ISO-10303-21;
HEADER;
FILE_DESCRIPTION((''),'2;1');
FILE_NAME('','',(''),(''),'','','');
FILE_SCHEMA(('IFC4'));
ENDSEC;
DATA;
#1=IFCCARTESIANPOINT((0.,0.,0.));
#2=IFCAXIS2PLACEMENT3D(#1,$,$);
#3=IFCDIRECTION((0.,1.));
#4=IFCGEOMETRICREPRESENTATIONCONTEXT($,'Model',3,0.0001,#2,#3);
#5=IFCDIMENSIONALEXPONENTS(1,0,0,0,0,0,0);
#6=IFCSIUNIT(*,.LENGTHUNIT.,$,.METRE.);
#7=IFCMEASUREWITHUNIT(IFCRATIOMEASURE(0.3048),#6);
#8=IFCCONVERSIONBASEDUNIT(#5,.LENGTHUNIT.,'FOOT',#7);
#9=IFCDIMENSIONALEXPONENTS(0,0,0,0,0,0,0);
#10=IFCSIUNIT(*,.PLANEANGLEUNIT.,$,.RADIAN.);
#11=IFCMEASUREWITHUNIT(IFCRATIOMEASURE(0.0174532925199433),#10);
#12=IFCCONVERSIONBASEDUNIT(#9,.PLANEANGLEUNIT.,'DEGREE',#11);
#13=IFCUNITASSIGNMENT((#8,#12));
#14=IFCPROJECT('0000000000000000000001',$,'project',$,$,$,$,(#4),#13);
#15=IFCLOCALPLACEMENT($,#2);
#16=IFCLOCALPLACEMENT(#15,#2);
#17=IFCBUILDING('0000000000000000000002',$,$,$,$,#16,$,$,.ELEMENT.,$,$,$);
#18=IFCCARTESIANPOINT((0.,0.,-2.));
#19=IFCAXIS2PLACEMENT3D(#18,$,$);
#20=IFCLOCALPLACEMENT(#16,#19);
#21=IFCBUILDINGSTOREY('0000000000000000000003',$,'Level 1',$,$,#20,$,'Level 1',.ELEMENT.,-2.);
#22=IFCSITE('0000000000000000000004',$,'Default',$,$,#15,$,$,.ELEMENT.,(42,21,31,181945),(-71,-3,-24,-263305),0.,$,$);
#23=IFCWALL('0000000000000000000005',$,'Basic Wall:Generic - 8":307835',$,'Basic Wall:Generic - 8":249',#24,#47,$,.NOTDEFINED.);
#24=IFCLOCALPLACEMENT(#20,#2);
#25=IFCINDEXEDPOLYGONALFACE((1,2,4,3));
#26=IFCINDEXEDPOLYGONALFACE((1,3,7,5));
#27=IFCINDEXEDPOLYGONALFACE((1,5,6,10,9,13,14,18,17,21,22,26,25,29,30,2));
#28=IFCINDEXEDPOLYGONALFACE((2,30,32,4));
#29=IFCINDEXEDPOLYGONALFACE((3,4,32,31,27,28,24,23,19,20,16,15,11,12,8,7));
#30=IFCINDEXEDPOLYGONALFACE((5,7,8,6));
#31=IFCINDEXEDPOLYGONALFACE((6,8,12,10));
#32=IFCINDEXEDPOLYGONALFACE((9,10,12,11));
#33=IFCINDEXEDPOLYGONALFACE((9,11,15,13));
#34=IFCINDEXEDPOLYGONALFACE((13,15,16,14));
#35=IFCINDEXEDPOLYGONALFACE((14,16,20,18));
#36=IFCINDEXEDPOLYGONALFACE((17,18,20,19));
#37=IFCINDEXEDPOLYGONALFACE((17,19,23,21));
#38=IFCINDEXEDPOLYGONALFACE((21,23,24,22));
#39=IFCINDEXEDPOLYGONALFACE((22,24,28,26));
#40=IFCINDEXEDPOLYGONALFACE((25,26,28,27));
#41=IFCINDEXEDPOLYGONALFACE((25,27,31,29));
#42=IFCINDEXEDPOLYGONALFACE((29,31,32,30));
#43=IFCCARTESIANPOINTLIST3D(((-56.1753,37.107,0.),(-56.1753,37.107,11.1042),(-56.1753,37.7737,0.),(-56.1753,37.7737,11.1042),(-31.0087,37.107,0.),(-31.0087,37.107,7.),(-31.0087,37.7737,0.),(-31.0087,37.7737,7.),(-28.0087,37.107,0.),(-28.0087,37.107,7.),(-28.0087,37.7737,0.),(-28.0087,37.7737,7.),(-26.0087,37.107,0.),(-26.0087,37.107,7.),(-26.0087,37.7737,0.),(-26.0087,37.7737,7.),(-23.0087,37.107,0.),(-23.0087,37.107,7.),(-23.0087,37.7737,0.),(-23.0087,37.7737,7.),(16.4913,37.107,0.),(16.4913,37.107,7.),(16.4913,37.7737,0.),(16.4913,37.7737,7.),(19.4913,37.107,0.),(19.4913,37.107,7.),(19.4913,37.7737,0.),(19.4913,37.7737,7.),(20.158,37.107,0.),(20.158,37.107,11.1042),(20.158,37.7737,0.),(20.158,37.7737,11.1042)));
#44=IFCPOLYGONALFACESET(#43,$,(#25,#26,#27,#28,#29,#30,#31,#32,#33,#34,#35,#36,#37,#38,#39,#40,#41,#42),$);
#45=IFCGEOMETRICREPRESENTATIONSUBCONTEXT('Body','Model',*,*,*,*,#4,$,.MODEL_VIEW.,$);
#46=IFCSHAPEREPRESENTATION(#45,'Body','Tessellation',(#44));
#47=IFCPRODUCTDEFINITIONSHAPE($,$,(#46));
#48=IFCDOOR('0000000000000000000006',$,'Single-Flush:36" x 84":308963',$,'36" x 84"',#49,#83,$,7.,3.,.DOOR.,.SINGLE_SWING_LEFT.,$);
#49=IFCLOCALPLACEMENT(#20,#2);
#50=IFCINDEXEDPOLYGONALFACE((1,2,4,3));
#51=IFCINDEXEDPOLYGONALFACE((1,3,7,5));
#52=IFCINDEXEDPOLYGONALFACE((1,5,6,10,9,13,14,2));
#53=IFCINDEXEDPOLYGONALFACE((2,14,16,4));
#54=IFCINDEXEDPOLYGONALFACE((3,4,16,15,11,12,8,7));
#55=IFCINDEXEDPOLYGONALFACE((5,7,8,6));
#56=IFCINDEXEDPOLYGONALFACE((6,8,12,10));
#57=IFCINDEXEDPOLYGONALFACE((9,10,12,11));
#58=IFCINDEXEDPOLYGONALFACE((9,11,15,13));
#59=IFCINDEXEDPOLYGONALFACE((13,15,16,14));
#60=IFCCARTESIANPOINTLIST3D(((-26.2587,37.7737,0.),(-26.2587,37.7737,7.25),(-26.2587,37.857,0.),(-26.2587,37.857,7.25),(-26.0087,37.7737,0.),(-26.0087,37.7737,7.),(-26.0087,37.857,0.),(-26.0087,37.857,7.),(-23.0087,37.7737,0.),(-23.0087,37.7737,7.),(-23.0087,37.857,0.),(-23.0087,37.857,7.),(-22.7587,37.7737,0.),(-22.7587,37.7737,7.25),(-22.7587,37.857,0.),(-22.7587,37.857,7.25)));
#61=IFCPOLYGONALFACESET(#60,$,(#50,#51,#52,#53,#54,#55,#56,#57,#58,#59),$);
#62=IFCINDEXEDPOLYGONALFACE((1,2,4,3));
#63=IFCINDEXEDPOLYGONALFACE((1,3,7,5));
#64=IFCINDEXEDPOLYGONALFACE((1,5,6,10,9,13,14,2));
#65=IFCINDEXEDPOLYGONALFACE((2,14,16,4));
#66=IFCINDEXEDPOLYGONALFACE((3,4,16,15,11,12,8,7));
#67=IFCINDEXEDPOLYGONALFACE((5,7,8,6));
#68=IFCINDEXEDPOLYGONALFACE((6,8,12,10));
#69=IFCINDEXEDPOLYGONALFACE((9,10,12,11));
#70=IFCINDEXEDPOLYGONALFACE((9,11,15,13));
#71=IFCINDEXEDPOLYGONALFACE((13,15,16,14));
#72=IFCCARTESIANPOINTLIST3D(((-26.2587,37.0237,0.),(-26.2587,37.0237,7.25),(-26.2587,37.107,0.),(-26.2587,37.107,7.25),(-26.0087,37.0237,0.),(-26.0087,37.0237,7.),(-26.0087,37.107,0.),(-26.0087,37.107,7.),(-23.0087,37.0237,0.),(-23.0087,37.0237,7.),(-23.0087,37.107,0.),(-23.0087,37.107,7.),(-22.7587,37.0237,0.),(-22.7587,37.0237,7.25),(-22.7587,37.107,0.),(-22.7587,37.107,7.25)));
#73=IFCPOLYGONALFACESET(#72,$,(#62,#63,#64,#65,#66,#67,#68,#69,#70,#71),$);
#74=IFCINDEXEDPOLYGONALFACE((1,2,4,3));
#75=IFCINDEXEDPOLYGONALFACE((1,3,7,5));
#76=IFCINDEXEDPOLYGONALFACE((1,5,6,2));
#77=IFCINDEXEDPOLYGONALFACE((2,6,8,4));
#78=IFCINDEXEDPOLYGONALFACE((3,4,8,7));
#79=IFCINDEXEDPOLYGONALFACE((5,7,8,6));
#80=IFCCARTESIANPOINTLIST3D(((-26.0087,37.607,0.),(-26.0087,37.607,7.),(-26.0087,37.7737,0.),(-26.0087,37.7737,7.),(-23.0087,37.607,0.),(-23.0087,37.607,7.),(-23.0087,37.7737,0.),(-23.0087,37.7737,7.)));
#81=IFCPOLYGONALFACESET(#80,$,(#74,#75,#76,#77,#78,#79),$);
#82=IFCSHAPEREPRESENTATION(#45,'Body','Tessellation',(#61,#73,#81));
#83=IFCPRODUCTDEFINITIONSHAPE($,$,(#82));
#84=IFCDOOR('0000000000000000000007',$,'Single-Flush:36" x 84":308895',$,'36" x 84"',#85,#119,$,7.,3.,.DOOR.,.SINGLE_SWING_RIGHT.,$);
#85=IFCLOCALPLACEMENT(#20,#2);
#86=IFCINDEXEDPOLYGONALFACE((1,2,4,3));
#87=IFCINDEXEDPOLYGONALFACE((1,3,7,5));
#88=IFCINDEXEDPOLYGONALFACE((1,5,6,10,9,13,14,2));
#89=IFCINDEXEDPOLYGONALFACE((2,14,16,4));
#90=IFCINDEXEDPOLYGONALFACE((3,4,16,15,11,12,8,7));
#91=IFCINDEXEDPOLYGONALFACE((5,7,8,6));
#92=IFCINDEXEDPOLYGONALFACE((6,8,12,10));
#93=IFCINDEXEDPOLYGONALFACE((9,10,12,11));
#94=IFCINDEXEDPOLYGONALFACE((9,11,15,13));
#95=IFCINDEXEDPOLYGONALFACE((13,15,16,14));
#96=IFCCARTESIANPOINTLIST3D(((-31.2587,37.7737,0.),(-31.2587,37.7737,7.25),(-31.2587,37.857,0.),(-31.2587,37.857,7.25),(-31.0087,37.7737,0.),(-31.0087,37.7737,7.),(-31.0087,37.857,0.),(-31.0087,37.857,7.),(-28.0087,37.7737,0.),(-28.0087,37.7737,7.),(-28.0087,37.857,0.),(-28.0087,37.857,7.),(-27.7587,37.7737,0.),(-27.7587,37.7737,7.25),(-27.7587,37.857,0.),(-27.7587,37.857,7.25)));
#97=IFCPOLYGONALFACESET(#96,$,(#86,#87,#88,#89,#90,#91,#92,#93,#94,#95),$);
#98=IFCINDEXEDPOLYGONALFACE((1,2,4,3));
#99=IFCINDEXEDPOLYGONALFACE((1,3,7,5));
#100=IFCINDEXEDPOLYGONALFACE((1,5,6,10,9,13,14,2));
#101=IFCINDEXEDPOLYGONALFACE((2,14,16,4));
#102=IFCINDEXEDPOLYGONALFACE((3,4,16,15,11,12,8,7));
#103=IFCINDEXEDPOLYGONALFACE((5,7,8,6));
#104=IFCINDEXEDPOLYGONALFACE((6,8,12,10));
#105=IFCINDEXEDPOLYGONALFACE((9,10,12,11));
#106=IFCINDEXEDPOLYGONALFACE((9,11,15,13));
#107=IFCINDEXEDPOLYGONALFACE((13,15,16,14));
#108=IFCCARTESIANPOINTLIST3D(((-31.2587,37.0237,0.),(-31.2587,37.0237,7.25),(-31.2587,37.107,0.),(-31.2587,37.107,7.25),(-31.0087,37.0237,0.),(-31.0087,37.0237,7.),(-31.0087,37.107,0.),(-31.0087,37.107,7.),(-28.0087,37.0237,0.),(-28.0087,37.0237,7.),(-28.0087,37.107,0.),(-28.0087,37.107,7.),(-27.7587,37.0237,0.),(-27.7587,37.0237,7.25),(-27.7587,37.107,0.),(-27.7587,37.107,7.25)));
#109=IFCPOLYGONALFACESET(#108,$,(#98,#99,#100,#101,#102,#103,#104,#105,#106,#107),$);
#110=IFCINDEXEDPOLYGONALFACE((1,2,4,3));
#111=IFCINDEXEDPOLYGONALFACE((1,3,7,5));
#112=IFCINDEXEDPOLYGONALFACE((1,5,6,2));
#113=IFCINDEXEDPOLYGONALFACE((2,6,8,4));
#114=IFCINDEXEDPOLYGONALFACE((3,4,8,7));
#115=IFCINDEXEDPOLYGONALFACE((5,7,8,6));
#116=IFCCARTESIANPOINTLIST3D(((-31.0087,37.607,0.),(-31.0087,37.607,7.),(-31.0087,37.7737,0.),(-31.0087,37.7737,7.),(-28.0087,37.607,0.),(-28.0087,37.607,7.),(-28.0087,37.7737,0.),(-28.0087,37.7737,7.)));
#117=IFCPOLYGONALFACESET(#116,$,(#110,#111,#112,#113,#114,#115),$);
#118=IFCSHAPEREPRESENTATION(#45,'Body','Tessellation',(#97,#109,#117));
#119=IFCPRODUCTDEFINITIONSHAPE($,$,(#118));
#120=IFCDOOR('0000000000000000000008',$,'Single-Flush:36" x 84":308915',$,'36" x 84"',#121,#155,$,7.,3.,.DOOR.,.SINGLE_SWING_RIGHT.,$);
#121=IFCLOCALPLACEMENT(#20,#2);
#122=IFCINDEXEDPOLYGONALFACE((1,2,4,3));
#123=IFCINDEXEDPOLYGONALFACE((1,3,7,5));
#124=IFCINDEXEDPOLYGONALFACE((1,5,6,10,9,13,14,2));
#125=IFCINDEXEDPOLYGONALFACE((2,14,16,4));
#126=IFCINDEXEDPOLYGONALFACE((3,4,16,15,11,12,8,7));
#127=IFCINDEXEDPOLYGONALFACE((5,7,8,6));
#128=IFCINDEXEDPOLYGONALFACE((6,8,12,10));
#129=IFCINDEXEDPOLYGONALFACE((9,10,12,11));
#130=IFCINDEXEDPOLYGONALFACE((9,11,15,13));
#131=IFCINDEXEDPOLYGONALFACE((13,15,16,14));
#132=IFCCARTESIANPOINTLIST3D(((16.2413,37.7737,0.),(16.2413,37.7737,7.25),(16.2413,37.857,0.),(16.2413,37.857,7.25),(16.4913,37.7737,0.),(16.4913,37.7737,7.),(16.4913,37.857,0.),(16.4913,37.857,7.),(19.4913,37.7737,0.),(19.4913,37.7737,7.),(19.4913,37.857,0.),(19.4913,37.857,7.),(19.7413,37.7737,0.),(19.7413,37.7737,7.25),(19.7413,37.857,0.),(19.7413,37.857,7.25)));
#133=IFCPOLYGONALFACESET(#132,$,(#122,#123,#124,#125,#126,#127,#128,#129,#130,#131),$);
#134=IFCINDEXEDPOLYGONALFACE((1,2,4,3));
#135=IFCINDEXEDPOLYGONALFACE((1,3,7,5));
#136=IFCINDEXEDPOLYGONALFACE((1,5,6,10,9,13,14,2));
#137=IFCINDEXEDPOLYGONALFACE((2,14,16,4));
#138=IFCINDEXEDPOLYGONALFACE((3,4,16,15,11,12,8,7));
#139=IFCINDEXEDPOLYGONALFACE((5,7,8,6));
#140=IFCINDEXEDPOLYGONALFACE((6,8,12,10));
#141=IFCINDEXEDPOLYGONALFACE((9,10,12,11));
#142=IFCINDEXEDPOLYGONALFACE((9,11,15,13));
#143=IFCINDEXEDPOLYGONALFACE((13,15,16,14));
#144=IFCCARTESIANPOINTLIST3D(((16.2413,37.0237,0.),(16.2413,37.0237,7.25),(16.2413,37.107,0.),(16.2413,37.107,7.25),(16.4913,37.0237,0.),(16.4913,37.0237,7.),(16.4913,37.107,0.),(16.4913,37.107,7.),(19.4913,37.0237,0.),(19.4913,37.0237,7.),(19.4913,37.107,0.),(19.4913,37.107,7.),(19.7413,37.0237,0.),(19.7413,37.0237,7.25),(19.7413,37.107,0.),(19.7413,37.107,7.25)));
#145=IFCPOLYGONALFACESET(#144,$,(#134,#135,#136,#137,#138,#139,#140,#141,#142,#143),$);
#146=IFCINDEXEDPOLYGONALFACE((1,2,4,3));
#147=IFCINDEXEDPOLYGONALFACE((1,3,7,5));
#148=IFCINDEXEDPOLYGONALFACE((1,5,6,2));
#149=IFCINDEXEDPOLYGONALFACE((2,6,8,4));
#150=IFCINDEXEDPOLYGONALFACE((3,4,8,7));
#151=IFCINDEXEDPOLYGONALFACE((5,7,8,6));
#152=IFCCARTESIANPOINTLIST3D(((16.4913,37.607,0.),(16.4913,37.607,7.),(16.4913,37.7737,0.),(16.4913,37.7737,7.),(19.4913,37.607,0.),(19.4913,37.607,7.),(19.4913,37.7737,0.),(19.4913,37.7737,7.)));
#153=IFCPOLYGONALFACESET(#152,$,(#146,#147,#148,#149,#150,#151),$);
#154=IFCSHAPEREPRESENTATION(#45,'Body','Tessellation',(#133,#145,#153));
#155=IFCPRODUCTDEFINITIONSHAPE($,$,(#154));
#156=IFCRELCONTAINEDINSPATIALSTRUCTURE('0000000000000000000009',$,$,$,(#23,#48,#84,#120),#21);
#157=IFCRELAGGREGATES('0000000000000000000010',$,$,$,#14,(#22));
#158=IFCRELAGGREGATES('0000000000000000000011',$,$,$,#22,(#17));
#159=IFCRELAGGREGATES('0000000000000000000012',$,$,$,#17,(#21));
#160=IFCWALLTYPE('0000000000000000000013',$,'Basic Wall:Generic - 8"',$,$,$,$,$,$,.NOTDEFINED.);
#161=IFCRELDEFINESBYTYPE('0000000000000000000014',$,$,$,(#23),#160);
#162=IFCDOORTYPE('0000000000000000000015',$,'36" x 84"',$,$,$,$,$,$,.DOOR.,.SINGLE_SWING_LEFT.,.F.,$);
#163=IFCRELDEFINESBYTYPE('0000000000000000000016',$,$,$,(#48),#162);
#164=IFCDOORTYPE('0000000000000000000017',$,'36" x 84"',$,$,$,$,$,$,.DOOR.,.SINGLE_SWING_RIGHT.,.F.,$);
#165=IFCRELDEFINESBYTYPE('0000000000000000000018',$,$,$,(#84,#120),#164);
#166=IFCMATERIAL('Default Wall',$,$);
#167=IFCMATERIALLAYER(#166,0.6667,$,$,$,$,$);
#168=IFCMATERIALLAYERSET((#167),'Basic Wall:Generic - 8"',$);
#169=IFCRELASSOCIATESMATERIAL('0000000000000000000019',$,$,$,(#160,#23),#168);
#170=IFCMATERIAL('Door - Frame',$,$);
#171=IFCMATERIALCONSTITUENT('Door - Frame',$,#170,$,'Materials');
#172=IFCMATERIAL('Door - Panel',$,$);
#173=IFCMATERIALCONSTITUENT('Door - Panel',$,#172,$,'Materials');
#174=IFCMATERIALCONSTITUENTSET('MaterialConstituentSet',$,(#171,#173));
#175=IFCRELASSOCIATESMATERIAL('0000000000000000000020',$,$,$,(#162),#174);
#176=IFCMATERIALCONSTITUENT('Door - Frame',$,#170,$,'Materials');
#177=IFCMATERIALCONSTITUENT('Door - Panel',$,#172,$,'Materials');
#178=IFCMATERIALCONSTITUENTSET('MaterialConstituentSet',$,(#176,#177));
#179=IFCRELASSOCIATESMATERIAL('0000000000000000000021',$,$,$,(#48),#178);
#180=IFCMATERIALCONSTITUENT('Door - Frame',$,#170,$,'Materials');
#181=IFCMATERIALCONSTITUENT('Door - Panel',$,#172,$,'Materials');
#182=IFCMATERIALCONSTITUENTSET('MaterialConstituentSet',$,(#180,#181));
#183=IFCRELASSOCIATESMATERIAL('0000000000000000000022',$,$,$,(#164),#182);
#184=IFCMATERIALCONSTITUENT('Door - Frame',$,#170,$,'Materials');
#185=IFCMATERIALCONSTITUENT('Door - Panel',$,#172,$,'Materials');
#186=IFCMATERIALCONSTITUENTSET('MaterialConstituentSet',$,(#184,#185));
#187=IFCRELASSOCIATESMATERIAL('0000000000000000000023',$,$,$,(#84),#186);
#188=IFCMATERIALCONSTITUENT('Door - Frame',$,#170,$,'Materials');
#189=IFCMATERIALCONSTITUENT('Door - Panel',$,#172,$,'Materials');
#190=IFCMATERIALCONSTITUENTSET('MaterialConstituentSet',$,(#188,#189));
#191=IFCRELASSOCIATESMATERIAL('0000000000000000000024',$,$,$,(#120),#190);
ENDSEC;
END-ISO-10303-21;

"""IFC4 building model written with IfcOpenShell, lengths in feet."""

from ifc_helpers import new_model, entity, si_unit, converted_unit, direction, frame, frame_2d, origin, place, context, subcontext, project, spatial, polyline, rectangle, outline, extrude, clip, bounded_halfspace, source, transform, mapped, material, layer, layer_set, layer_usage, constituent, constituent_set, type_object, type_shapes, element, fill, save


model = new_model("IFC4")

# Units and contexts
model_context = context("Model", 3, precision=0.0001, world=origin(), true_north=direction((0.0, 1.0)))
body_context = subcontext(model_context, "Body", "Model", "MODEL_VIEW")
ifc_project = project(units=[converted_unit("LENGTHUNIT", "FOOT", entity("IfcRatioMeasure", 0.3048), si_unit("LENGTHUNIT", "METRE"), dimensions=[1, 0, 0, 0, 0, 0, 0]), converted_unit("PLANEANGLEUNIT", "DEGREE", entity("IfcRatioMeasure", 0.0174532925199433), si_unit("PLANEANGLEUNIT", "RADIAN"), dimensions=[0, 0, 0, 0, 0, 0, 0])], contexts=[model_context])

# Site, building, storey
site_placement = place(None, origin())
site = spatial("IfcSite", under=ifc_project, at=site_placement, Name="Default", CompositionType="ELEMENT", RefLatitude=(42, 21, 31, 181945), RefLongitude=(-71, -3, -24, -263305), RefElevation=0.0)
building_placement = place(site_placement, origin())
building = spatial("IfcBuilding", under=site, at=building_placement, CompositionType="ELEMENT")
storey_placement = place(building_placement, frame((0.0, 0.0, -2.0)))
storey = spatial("IfcBuildingStorey", under=building, at=storey_placement, Name="Level 1", LongName="Level 1", CompositionType="ELEMENT", Elevation=-2.0)

# Shared definitions
ifc_material_1 = material(Name="Default Wall")
ifc_layer = layer(ifc_material_1, 0.6667)
ifc_layer_set = layer_set([ifc_layer], Name="Basic Wall:Generic - 8\"")
wall_type = type_object("IfcWallType", Name="Basic Wall:Generic - 8\"", PredefinedType="NOTDEFINED", material=ifc_layer_set)

# Wall, openings, doors
ifc_layer_usage_1 = layer_usage(ifc_layer_set, "AXIS2", "NEGATIVE", 0.3333)
wall_1_placement = place(storey_placement, frame((-56.1753, 37.4404, 0.0)))
wall_1 = element("IfcWall", 1, at=wall_1_placement, inside=storey, type_object=wall_type, material=ifc_layer_usage_1, Name="Basic Wall:Generic - 8\":307835", ObjectType="Basic Wall:Generic - 8\":249", PredefinedType="NOTDEFINED", context=body_context, shape_type="Clipping", body=[
    clip(extrude(rectangle(XDim=76.3333, YDim=0.6667, at=frame_2d((38.1667, 0.0), x_axis=(-1.0, 0.0))), origin(), (0.0, 0.0, 1.0), 11.1042), bounded_halfspace(frame((0.0, -0.3333, 11.1042), z_axis=(0.0, 0.0, -1.0), x_axis=(0.0, -1.0, 0.0)), True, frame((0.0, -0.3333, 11.1042), z_axis=(0.0, 0.0, -1.0), x_axis=(0.0, -1.0, 0.0)), polyline([(0.0, 0.0), (-0.6667, 0.0), (-0.6667, -28.8333), (-0.6667, -29.5), (-0.6667, -76.3333), (0.0, -76.3333), (0.0, -20.5), (0.0, -19.8333), (0.0, 0.0)]))),
])
opening_1_placement = place(wall_1_placement, frame((25.1667, -0.3333, 0.0)))
opening_1 = element("IfcOpeningElement", 2, at=opening_1_placement, cuts=wall_1, ObjectType="Opening", PredefinedType="OPENING", context=body_context, shape_type="SweptSolid", body=[
    extrude(rectangle(XDim=3.0, YDim=7.0, at=frame_2d((3.5, 1.5), x_axis=(0.0, 1.0))), frame((0.0, 0.0, 0.0), z_axis=(0.0, 1.0, 0.0), x_axis=(0.0, 0.0, 1.0)), (0.0, 0.0, 1.0), 0.6667),
])
opening_2_placement = place(wall_1_placement, frame((72.6667, -0.3333, 0.0)))
opening_2 = element("IfcOpeningElement", 3, at=opening_2_placement, cuts=wall_1, ObjectType="Opening", PredefinedType="OPENING", context=body_context, shape_type="SweptSolid", body=[
    extrude(rectangle(XDim=3.0, YDim=7.0, at=frame_2d((3.5, 1.5), x_axis=(0.0, 1.0))), frame((0.0, 0.0, 0.0), z_axis=(0.0, 1.0, 0.0), x_axis=(0.0, 0.0, 1.0)), (0.0, 0.0, 1.0), 0.6667),
])
opening_3_placement = place(wall_1_placement, frame((30.1667, -0.3333, 0.0)))
opening_3 = element("IfcOpeningElement", 4, at=opening_3_placement, cuts=wall_1, ObjectType="Opening", PredefinedType="OPENING", context=body_context, shape_type="SweptSolid", body=[
    extrude(rectangle(XDim=3.0, YDim=7.0, at=frame_2d((3.5, 1.5), x_axis=(0.0, -1.0))), frame((0.0, 0.0, 0.0), z_axis=(0.0, 1.0, 0.0), x_axis=(0.0, 0.0, 1.0)), (0.0, 0.0, 1.0), 0.6667),
])
ifc_material_2 = material(Name="Door - Frame")
ifc_constituent_1 = constituent(ifc_material_2, Name="Door - Frame", Category="Materials")
ifc_material_3 = material(Name="Door - Panel")
ifc_constituent_2 = constituent(ifc_material_3, Name="Door - Panel", Category="Materials")
ifc_constituent_set_1 = constituent_set(constituents=[ifc_constituent_1, ifc_constituent_2], Name="MaterialConstituentSet")
ifc_constituent_3 = constituent(ifc_material_2, Name="Door - Frame", Category="Materials")
ifc_constituent_4 = constituent(ifc_material_3, Name="Door - Panel", Category="Materials")
ifc_constituent_set_2 = constituent_set(constituents=[ifc_constituent_3, ifc_constituent_4], Name="MaterialConstituentSet")
door_type_1 = type_object("IfcDoorType", Name="36\" x 84\"", OperationType="SINGLE_SWING_LEFT", ParameterTakesPrecedence=False, PredefinedType="DOOR", material=ifc_constituent_set_2)
shared_shape_1 = source(origin(), body_context, "Body", "SweptSolid", [
    extrude(outline(polyline([(-1.75, -3.6875), (1.75, -3.6875), (1.75, 3.5625), (1.5, 3.5625), (1.5, -3.4375), (-1.5, -3.4375), (-1.5, 3.5625), (-1.75, 3.5625), (-1.75, -3.6875)])), frame((1.5, 0.75, 3.5625), z_axis=(0.0, -1.0, 0.0), x_axis=(-1.0, 0.0, 0.0)), (0.0, 0.0, 1.0), 0.0833),
    extrude(outline(polyline([(-3.6875, -1.75), (3.5625, -1.75), (3.5625, -1.5), (-3.4375, -1.5), (-3.4375, 1.5), (3.5625, 1.5), (3.5625, 1.75), (-3.6875, 1.75), (-3.6875, -1.75)])), frame((1.5, 0.0, 3.5625), z_axis=(0.0, -1.0, 0.0), x_axis=(0.0, 0.0, -1.0)), (0.0, 0.0, 1.0), 0.0833),
    extrude(rectangle(XDim=3.0, YDim=0.1667, at=frame_2d((0.0, 0.0), x_axis=(1.0, 0.0))), frame((1.5, 0.5833, 0.0)), (0.0, 0.0, 1.0), 7.0),
])
type_shapes(door_type_1, [shared_shape_1])
door_1_placement = place(opening_3_placement, origin())
door_1 = element("IfcDoor", 5, at=door_1_placement, inside=storey, type_object=door_type_1, material=ifc_constituent_set_1, Name="Single-Flush:36\" x 84\":308963", ObjectType="36\" x 84\"", OperationType="SINGLE_SWING_LEFT", OverallHeight=7.0, OverallWidth=3.0, PredefinedType="DOOR", context=body_context, shape_type="MappedRepresentation", body=[
    mapped(shared_shape_1, transform((0.0, 0.0, 0.0), scale=1.0)),
])
fill(opening_3, door_1)
ifc_constituent_5 = constituent(ifc_material_2, Name="Door - Frame", Category="Materials")
ifc_constituent_6 = constituent(ifc_material_3, Name="Door - Panel", Category="Materials")
ifc_constituent_set_3 = constituent_set(constituents=[ifc_constituent_5, ifc_constituent_6], Name="MaterialConstituentSet")
ifc_constituent_7 = constituent(ifc_material_2, Name="Door - Frame", Category="Materials")
ifc_constituent_8 = constituent(ifc_material_3, Name="Door - Panel", Category="Materials")
ifc_constituent_set_4 = constituent_set(constituents=[ifc_constituent_7, ifc_constituent_8], Name="MaterialConstituentSet")
door_type_2 = type_object("IfcDoorType", Name="36\" x 84\"", OperationType="SINGLE_SWING_RIGHT", ParameterTakesPrecedence=False, PredefinedType="DOOR", material=ifc_constituent_set_4)
shared_shape_2 = source(origin(), body_context, "Body", "SweptSolid", [
    extrude(outline(polyline([(-1.75, -3.6875), (1.75, -3.6875), (1.75, 3.5625), (1.5, 3.5625), (1.5, -3.4375), (-1.5, -3.4375), (-1.5, 3.5625), (-1.75, 3.5625), (-1.75, -3.6875)])), frame((1.5, 0.6667, 3.5625), z_axis=(0.0, 1.0, 0.0), x_axis=(1.0, 0.0, 0.0)), (0.0, 0.0, 1.0), 0.0833),
    extrude(outline(polyline([(-3.6875, -1.75), (3.5625, -1.75), (3.5625, -1.5), (-3.4375, -1.5), (-3.4375, 1.5), (3.5625, 1.5), (3.5625, 1.75), (-3.6875, 1.75), (-3.6875, -1.75)])), frame((1.5, -0.0833, 3.5625), z_axis=(0.0, 1.0, 0.0), x_axis=(0.0, 0.0, -1.0)), (0.0, 0.0, 1.0), 0.0833),
    extrude(rectangle(XDim=0.1667, YDim=3.0, at=frame_2d((0.0, 0.0), x_axis=(1.0, 0.0))), frame((1.5, 0.5833, 0.0), z_axis=(0.0, 0.0, 1.0), x_axis=(0.0, 1.0, 0.0)), (0.0, 0.0, 1.0), 7.0),
])
type_shapes(door_type_2, [shared_shape_2])
door_2_placement = place(opening_1_placement, origin())
door_2 = element("IfcDoor", 6, at=door_2_placement, inside=storey, type_object=door_type_2, material=ifc_constituent_set_3, Name="Single-Flush:36\" x 84\":308895", ObjectType="36\" x 84\"", OperationType="SINGLE_SWING_RIGHT", OverallHeight=7.0, OverallWidth=3.0, PredefinedType="DOOR", context=body_context, shape_type="MappedRepresentation", body=[
    mapped(shared_shape_2, transform((0.0, 0.0, 0.0), scale=1.0)),
])
fill(opening_1, door_2)
ifc_constituent_9 = constituent(ifc_material_2, Name="Door - Frame", Category="Materials")
ifc_constituent_10 = constituent(ifc_material_3, Name="Door - Panel", Category="Materials")
ifc_constituent_set_5 = constituent_set(constituents=[ifc_constituent_9, ifc_constituent_10], Name="MaterialConstituentSet")
door_3_placement = place(opening_2_placement, origin())
door_3 = element("IfcDoor", 7, at=door_3_placement, inside=storey, type_object=door_type_2, material=ifc_constituent_set_5, Name="Single-Flush:36\" x 84\":308915", ObjectType="36\" x 84\"", OperationType="SINGLE_SWING_RIGHT", OverallHeight=7.0, OverallWidth=3.0, PredefinedType="DOOR", context=body_context, shape_type="MappedRepresentation", body=[
    mapped(shared_shape_2, transform((0.0, 0.0, 0.0), scale=1.0)),
])
fill(opening_2, door_3)

save(model, "model.ifc")
